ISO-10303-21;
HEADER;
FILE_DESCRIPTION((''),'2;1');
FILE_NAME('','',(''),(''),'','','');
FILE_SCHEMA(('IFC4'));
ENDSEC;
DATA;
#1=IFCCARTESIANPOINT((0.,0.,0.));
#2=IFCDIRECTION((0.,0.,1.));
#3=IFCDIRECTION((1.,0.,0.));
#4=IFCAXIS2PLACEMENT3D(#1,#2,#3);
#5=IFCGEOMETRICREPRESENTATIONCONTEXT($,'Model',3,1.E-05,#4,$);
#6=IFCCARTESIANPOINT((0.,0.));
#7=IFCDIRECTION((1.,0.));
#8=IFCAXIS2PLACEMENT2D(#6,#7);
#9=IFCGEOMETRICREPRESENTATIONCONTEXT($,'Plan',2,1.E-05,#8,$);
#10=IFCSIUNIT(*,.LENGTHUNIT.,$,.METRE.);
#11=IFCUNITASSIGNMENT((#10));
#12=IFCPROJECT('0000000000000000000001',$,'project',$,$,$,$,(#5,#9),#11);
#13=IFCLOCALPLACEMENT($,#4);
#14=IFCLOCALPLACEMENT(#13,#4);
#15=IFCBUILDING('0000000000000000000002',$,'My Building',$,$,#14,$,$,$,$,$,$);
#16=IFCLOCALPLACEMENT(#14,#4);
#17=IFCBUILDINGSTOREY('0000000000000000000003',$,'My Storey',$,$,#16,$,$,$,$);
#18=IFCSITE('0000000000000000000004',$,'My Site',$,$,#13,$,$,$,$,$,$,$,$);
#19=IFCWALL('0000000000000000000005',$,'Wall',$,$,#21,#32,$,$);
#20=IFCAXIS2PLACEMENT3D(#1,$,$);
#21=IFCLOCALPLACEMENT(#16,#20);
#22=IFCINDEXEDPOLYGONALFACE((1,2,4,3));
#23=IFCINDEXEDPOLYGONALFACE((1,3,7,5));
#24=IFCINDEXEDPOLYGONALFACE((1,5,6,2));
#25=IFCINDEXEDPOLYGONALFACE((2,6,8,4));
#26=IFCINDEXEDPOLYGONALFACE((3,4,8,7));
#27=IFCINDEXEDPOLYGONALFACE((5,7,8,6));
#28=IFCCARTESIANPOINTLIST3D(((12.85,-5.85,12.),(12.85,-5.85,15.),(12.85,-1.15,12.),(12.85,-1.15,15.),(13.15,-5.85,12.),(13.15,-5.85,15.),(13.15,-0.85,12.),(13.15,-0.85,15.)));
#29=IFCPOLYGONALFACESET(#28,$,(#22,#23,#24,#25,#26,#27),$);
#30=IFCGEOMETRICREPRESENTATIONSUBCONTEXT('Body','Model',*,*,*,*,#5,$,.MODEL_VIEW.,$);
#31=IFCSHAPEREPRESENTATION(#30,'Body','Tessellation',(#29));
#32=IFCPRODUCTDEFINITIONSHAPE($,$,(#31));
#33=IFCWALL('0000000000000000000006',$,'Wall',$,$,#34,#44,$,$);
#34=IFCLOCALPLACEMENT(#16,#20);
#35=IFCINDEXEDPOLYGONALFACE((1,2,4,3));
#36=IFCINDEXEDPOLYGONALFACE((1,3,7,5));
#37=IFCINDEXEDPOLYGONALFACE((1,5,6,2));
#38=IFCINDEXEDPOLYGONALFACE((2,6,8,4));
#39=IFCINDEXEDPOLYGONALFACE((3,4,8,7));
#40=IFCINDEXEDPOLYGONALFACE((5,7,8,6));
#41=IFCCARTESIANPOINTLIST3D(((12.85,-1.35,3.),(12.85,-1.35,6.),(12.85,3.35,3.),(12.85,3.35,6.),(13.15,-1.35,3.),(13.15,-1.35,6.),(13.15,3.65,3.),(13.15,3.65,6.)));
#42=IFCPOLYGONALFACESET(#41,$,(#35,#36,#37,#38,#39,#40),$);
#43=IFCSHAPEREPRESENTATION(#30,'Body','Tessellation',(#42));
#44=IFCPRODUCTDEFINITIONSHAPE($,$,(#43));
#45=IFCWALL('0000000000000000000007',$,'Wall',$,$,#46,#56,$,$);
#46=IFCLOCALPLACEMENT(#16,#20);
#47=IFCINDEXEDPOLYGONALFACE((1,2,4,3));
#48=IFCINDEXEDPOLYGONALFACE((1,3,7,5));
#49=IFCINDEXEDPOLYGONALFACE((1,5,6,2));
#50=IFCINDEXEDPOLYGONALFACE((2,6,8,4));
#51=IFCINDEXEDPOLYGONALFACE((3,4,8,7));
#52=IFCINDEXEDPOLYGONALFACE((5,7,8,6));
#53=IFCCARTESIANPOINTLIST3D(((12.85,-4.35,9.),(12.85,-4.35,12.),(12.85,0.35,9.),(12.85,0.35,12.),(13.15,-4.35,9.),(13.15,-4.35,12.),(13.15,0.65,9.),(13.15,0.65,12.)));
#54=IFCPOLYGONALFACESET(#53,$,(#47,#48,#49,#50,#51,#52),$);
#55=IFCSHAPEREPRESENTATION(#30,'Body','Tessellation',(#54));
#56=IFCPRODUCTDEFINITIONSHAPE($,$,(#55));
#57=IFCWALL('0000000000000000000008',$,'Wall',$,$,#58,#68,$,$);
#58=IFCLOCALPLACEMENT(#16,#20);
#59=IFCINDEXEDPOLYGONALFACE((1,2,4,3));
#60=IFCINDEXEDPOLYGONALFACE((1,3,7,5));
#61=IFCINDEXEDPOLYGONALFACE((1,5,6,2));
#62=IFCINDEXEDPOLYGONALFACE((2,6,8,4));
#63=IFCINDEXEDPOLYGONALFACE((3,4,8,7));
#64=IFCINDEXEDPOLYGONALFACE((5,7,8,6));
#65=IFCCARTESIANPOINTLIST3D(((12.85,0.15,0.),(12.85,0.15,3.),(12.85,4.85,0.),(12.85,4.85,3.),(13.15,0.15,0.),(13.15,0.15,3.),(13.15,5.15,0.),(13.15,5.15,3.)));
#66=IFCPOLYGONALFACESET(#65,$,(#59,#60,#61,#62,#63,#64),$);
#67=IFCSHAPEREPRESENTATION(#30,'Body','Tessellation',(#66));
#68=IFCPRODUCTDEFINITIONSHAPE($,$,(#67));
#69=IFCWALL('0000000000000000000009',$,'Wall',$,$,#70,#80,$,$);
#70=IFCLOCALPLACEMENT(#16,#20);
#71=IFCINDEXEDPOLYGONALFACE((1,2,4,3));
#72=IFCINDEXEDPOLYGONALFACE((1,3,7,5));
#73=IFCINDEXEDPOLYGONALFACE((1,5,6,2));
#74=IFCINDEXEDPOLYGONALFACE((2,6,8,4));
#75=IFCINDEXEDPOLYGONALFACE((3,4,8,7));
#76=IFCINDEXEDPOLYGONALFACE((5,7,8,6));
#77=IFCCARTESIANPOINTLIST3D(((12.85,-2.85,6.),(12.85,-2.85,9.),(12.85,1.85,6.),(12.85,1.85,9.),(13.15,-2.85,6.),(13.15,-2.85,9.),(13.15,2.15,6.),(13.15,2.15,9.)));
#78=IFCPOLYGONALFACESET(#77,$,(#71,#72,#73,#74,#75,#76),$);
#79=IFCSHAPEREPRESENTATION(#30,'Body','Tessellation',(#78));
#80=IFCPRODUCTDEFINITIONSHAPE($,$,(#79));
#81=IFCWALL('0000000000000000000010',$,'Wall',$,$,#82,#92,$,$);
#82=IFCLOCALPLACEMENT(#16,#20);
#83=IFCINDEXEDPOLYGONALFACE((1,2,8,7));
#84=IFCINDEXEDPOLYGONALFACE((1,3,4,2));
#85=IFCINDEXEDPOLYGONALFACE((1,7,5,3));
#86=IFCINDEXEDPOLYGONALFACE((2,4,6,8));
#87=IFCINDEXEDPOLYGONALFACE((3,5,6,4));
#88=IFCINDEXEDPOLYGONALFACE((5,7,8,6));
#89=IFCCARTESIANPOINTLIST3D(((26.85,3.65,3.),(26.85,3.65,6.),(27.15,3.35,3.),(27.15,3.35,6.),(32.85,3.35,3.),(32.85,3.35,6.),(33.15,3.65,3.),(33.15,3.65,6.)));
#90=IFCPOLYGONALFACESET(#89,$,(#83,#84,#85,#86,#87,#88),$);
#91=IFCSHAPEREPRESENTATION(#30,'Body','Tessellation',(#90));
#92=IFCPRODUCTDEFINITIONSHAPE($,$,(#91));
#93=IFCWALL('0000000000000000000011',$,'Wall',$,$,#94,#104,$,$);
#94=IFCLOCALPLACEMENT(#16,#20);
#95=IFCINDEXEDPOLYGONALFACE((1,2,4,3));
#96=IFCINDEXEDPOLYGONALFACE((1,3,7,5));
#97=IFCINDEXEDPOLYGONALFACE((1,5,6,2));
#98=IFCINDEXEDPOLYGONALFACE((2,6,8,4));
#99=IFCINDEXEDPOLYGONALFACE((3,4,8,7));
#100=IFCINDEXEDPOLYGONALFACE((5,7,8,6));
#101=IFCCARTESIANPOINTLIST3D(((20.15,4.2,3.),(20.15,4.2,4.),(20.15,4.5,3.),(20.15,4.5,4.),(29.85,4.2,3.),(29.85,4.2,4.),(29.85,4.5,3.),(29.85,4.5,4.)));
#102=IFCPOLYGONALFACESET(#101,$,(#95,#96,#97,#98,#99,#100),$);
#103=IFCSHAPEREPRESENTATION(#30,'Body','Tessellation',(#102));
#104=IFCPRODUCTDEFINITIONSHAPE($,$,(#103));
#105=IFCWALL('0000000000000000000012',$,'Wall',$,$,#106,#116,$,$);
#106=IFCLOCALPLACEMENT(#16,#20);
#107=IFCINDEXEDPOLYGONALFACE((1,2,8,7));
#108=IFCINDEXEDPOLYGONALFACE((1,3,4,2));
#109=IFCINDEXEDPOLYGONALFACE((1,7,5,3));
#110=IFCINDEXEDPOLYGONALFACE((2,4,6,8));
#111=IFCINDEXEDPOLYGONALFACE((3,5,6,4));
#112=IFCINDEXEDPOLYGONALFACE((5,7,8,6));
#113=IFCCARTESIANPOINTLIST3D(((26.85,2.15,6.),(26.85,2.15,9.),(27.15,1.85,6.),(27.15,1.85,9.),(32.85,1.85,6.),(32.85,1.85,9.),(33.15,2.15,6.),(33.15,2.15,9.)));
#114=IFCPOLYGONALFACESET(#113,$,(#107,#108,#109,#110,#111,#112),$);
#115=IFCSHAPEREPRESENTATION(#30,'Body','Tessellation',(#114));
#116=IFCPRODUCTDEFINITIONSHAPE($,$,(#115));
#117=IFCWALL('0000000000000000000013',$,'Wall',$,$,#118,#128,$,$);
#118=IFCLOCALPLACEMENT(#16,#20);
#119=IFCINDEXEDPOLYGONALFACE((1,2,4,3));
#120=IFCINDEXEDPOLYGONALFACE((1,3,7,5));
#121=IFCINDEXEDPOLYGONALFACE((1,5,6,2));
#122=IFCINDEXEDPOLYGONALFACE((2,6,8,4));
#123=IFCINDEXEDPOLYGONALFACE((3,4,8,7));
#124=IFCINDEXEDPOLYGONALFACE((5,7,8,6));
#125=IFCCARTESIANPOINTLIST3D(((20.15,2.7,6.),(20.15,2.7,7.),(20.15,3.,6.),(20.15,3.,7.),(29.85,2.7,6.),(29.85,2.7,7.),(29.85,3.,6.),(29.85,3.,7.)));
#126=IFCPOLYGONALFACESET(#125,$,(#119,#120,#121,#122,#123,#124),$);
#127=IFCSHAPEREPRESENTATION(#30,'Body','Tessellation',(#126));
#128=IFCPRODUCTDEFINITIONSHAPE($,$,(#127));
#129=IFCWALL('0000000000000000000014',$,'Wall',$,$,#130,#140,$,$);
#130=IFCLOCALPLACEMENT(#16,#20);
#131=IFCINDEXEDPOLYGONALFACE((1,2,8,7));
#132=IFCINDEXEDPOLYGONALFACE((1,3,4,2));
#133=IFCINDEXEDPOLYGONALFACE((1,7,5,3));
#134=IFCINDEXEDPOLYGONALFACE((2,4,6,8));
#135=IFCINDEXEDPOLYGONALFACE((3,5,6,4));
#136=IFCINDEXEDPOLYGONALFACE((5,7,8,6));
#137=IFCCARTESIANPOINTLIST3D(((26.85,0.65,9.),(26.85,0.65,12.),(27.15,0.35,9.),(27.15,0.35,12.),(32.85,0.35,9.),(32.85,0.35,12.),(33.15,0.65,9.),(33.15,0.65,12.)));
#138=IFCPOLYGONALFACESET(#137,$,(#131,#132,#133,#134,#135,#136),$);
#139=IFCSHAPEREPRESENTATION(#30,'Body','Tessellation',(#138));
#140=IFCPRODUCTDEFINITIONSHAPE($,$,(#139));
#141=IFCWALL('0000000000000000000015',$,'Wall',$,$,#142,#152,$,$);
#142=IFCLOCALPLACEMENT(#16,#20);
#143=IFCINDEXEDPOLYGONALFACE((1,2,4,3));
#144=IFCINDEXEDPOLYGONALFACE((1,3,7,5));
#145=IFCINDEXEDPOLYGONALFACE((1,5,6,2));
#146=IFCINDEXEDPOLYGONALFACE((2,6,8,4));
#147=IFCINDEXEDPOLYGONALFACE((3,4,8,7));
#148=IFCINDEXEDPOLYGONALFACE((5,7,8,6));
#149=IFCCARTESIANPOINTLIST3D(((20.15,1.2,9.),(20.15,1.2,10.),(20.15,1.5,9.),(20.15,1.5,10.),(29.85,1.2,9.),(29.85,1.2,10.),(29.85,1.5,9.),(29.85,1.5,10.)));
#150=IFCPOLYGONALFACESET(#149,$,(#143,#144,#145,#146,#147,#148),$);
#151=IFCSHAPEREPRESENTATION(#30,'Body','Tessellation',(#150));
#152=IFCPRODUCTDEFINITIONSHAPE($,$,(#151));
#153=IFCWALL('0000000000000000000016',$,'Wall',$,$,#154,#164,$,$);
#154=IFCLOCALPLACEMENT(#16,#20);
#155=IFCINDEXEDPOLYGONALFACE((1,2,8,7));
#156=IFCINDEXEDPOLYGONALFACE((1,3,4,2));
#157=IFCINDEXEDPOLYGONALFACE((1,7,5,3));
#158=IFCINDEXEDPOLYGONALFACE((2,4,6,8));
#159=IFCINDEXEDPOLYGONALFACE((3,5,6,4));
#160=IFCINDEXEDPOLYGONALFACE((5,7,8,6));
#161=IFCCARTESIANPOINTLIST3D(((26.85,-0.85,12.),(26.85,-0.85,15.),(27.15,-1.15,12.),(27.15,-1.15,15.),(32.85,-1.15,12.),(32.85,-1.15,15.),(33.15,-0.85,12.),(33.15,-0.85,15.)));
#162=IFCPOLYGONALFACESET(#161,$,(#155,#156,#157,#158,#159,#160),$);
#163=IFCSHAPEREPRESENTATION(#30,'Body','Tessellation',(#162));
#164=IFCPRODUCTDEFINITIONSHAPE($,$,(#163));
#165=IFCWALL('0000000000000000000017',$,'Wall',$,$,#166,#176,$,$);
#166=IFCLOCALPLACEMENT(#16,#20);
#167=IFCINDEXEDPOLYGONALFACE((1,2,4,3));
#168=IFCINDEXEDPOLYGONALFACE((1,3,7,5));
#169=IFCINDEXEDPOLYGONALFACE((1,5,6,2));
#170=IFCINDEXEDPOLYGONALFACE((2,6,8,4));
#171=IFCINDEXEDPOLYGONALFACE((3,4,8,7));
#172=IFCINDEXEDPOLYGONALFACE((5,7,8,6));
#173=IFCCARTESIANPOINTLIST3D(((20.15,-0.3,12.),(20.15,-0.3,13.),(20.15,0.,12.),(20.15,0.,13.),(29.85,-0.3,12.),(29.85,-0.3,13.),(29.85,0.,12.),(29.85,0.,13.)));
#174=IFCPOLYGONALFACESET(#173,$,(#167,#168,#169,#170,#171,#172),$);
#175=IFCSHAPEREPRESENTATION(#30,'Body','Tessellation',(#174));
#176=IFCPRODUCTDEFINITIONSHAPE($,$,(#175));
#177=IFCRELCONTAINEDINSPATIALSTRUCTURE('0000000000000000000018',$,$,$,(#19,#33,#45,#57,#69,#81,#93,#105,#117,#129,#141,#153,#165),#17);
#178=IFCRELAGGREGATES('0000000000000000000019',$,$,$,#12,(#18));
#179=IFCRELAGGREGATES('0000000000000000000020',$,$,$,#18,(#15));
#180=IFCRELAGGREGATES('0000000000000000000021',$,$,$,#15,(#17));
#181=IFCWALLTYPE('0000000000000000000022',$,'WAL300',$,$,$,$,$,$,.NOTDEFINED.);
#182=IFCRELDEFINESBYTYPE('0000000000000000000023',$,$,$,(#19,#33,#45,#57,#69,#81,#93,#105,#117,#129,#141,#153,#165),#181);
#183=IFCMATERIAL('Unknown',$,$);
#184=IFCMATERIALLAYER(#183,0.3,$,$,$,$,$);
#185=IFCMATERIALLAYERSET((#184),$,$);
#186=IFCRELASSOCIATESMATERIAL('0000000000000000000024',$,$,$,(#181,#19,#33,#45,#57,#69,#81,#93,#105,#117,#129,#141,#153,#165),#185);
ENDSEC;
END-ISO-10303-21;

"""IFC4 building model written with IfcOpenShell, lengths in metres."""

from ifc_helpers import new_model, si_unit, frame, origin_with_axes, origin_2d_with_axis, place, context, subcontext, project, spatial, line, indexed_curve, outline, extrude, material, layer, layer_set, layer_usage, type_object, element, save


model = new_model("IFC4")

# Units and contexts
model_context = context("Model", 3, precision=1e-05, world=origin_with_axes())
plan_context = context("Plan", 2, precision=1e-05, world=origin_2d_with_axis())
body_context = subcontext(model_context, "Body", "Model", "MODEL_VIEW")
ifc_project = project(units=[si_unit("LENGTHUNIT", "METRE")], contexts=[model_context, plan_context])

# Site, building, storey
site_placement = place(None, origin_with_axes())
site = spatial("IfcSite", under=ifc_project, at=site_placement, Name="My Site")
building_placement = place(site_placement, origin_with_axes())
building = spatial("IfcBuilding", under=site, at=building_placement, Name="My Building")
storey_placement = place(building_placement, origin_with_axes())
storey = spatial("IfcBuildingStorey", under=building, at=storey_placement, Name="My Storey")

# Walls
ifc_material = material(Name="Unknown")
ifc_layer = layer(ifc_material, 0.3)
ifc_layer_set = layer_set([ifc_layer])
wall_type = type_object("IfcWallType", Name="WAL300", PredefinedType="NOTDEFINED", material=ifc_layer_set)
ifc_layer_usage_1 = layer_usage(ifc_layer_set, "AXIS2", "POSITIVE", -0.15)
wall_1_placement = place(storey_placement, frame((13.0, -6.0, 12.0), z_axis=(0.0, 0.0, 1.0), x_axis=(0.0, 1.0, 0.0)))
element("IfcWall", 1, at=wall_1_placement, inside=storey, type_object=wall_type, material=ifc_layer_usage_1, Name="Wall", context=body_context, shape_type="SweptSolid", body=[
    extrude(outline(indexed_curve([(0.15, -0.15), (0.15, 0.15), (4.85, 0.15), (5.15, -0.15)], segments=[line(1, 2, 3, 4, 1)])), origin_with_axes(), (0.0, 0.0, 1.0), 3.0),
])
ifc_layer_usage_2 = layer_usage(ifc_layer_set, "AXIS2", "POSITIVE", -0.15)
wall_2_placement = place(storey_placement, frame((13.0, -1.5, 3.0), z_axis=(0.0, 0.0, 1.0), x_axis=(0.0, 1.0, 0.0)))
element("IfcWall", 2, at=wall_2_placement, inside=storey, type_object=wall_type, material=ifc_layer_usage_2, Name="Wall", context=body_context, shape_type="SweptSolid", body=[
    extrude(outline(indexed_curve([(0.15, -0.15), (0.15, 0.15), (4.85, 0.15), (5.15, -0.15)], segments=[line(1, 2, 3, 4, 1)])), origin_with_axes(), (0.0, 0.0, 1.0), 3.0),
])
ifc_layer_usage_3 = layer_usage(ifc_layer_set, "AXIS2", "POSITIVE", -0.15)
wall_3_placement = place(storey_placement, frame((13.0, -4.5, 9.0), z_axis=(0.0, 0.0, 1.0), x_axis=(0.0, 1.0, 0.0)))
element("IfcWall", 3, at=wall_3_placement, inside=storey, type_object=wall_type, material=ifc_layer_usage_3, Name="Wall", context=body_context, shape_type="SweptSolid", body=[
    extrude(outline(indexed_curve([(0.15, -0.15), (0.15, 0.15), (4.85, 0.15), (5.15, -0.15)], segments=[line(1, 2, 3, 4, 1)])), origin_with_axes(), (0.0, 0.0, 1.0), 3.0),
])
ifc_layer_usage_4 = layer_usage(ifc_layer_set, "AXIS2", "POSITIVE", -0.15)
wall_4_placement = place(storey_placement, frame((13.0, 0.0, 0.0), z_axis=(0.0, 0.0, 1.0), x_axis=(0.0, 1.0, 0.0)))
element("IfcWall", 4, at=wall_4_placement, inside=storey, type_object=wall_type, material=ifc_layer_usage_4, Name="Wall", context=body_context, shape_type="SweptSolid", body=[
    extrude(outline(indexed_curve([(0.15, -0.15), (0.15, 0.15), (4.85, 0.15), (5.15, -0.15)], segments=[line(1, 2, 3, 4, 1)])), origin_with_axes(), (0.0, 0.0, 1.0), 3.0),
])
ifc_layer_usage_5 = layer_usage(ifc_layer_set, "AXIS2", "POSITIVE", -0.15)
wall_5_placement = place(storey_placement, frame((13.0, -3.0, 6.0), z_axis=(0.0, 0.0, 1.0), x_axis=(0.0, 1.0, 0.0)))
element("IfcWall", 5, at=wall_5_placement, inside=storey, type_object=wall_type, material=ifc_layer_usage_5, Name="Wall", context=body_context, shape_type="SweptSolid", body=[
    extrude(outline(indexed_curve([(0.15, -0.15), (0.15, 0.15), (4.85, 0.15), (5.15, -0.15)], segments=[line(1, 2, 3, 4, 1)])), origin_with_axes(), (0.0, 0.0, 1.0), 3.0),
])
ifc_layer_usage_6 = layer_usage(ifc_layer_set, "AXIS2", "POSITIVE", -0.15)
wall_6_placement = place(storey_placement, frame((27.0, 3.5, 3.0), z_axis=(0.0, 0.0, 1.0), x_axis=(1.0, 0.0, 0.0)))
element("IfcWall", 6, at=wall_6_placement, inside=storey, type_object=wall_type, material=ifc_layer_usage_6, Name="Wall", context=body_context, shape_type="SweptSolid", body=[
    extrude(outline(indexed_curve([(0.15, -0.15), (-0.15, 0.15), (6.15, 0.15), (5.85, -0.15)], segments=[line(1, 2, 3, 4, 1)])), origin_with_axes(), (0.0, 0.0, 1.0), 3.0),
])
ifc_layer_usage_7 = layer_usage(ifc_layer_set, "AXIS2", "POSITIVE", -0.3)
wall_7_placement = place(storey_placement, frame((20.15, 4.5, 3.0), z_axis=(0.0, 0.0, 1.0), x_axis=(1.0, 0.0, 0.0)))
element("IfcWall", 7, at=wall_7_placement, inside=storey, type_object=wall_type, material=ifc_layer_usage_7, Name="Wall", context=body_context, shape_type="SweptSolid", body=[
    extrude(outline(indexed_curve([(0.0, -0.3), (0.0, 0.0), (9.7, 0.0), (9.7, -0.3)], segments=[line(1, 2, 3, 4, 1)])), origin_with_axes(), (0.0, 0.0, 1.0), 1.0),
])
ifc_layer_usage_8 = layer_usage(ifc_layer_set, "AXIS2", "POSITIVE", -0.15)
wall_8_placement = place(storey_placement, frame((27.0, 2.0, 6.0), z_axis=(0.0, 0.0, 1.0), x_axis=(1.0, 0.0, 0.0)))
element("IfcWall", 8, at=wall_8_placement, inside=storey, type_object=wall_type, material=ifc_layer_usage_8, Name="Wall", context=body_context, shape_type="SweptSolid", body=[
    extrude(outline(indexed_curve([(0.15, -0.15), (-0.15, 0.15), (6.15, 0.15), (5.85, -0.15)], segments=[line(1, 2, 3, 4, 1)])), origin_with_axes(), (0.0, 0.0, 1.0), 3.0),
])
ifc_layer_usage_9 = layer_usage(ifc_layer_set, "AXIS2", "POSITIVE", -0.3)
wall_9_placement = place(storey_placement, frame((20.15, 3.0, 6.0), z_axis=(0.0, 0.0, 1.0), x_axis=(1.0, 0.0, 0.0)))
element("IfcWall", 9, at=wall_9_placement, inside=storey, type_object=wall_type, material=ifc_layer_usage_9, Name="Wall", context=body_context, shape_type="SweptSolid", body=[
    extrude(outline(indexed_curve([(0.0, -0.3), (0.0, 0.0), (9.7, 0.0), (9.7, -0.3)], segments=[line(1, 2, 3, 4, 1)])), origin_with_axes(), (0.0, 0.0, 1.0), 1.0),
])
ifc_layer_usage_10 = layer_usage(ifc_layer_set, "AXIS2", "POSITIVE", -0.15)
wall_10_placement = place(storey_placement, frame((27.0, 0.5, 9.0), z_axis=(0.0, 0.0, 1.0), x_axis=(1.0, 0.0, 0.0)))
element("IfcWall", 10, at=wall_10_placement, inside=storey, type_object=wall_type, material=ifc_layer_usage_10, Name="Wall", context=body_context, shape_type="SweptSolid", body=[
    extrude(outline(indexed_curve([(0.15, -0.15), (-0.15, 0.15), (6.15, 0.15), (5.85, -0.15)], segments=[line(1, 2, 3, 4, 1)])), origin_with_axes(), (0.0, 0.0, 1.0), 3.0),
])
ifc_layer_usage_11 = layer_usage(ifc_layer_set, "AXIS2", "POSITIVE", -0.3)
wall_11_placement = place(storey_placement, frame((20.15, 1.5, 9.0), z_axis=(0.0, 0.0, 1.0), x_axis=(1.0, 0.0, 0.0)))
element("IfcWall", 11, at=wall_11_placement, inside=storey, type_object=wall_type, material=ifc_layer_usage_11, Name="Wall", context=body_context, shape_type="SweptSolid", body=[
    extrude(outline(indexed_curve([(0.0, -0.3), (0.0, 0.0), (9.7, 0.0), (9.7, -0.3)], segments=[line(1, 2, 3, 4, 1)])), origin_with_axes(), (0.0, 0.0, 1.0), 1.0),
])
ifc_layer_usage_12 = layer_usage(ifc_layer_set, "AXIS2", "POSITIVE", -0.15)
wall_12_placement = place(storey_placement, frame((27.0, -1.0, 12.0), z_axis=(0.0, 0.0, 1.0), x_axis=(1.0, 0.0, 0.0)))
element("IfcWall", 12, at=wall_12_placement, inside=storey, type_object=wall_type, material=ifc_layer_usage_12, Name="Wall", context=body_context, shape_type="SweptSolid", body=[
    extrude(outline(indexed_curve([(0.15, -0.15), (-0.15, 0.15), (6.15, 0.15), (5.85, -0.15)], segments=[line(1, 2, 3, 4, 1)])), origin_with_axes(), (0.0, 0.0, 1.0), 3.0),
])
ifc_layer_usage_13 = layer_usage(ifc_layer_set, "AXIS2", "POSITIVE", -0.3)
wall_13_placement = place(storey_placement, frame((20.15, 0.0, 12.0), z_axis=(0.0, 0.0, 1.0), x_axis=(1.0, 0.0, 0.0)))
element("IfcWall", 13, at=wall_13_placement, inside=storey, type_object=wall_type, material=ifc_layer_usage_13, Name="Wall", context=body_context, shape_type="SweptSolid", body=[
    extrude(outline(indexed_curve([(0.0, -0.3), (0.0, 0.0), (9.7, 0.0), (9.7, -0.3)], segments=[line(1, 2, 3, 4, 1)])), origin_with_axes(), (0.0, 0.0, 1.0), 1.0),
])

save(model, "model.ifc")
